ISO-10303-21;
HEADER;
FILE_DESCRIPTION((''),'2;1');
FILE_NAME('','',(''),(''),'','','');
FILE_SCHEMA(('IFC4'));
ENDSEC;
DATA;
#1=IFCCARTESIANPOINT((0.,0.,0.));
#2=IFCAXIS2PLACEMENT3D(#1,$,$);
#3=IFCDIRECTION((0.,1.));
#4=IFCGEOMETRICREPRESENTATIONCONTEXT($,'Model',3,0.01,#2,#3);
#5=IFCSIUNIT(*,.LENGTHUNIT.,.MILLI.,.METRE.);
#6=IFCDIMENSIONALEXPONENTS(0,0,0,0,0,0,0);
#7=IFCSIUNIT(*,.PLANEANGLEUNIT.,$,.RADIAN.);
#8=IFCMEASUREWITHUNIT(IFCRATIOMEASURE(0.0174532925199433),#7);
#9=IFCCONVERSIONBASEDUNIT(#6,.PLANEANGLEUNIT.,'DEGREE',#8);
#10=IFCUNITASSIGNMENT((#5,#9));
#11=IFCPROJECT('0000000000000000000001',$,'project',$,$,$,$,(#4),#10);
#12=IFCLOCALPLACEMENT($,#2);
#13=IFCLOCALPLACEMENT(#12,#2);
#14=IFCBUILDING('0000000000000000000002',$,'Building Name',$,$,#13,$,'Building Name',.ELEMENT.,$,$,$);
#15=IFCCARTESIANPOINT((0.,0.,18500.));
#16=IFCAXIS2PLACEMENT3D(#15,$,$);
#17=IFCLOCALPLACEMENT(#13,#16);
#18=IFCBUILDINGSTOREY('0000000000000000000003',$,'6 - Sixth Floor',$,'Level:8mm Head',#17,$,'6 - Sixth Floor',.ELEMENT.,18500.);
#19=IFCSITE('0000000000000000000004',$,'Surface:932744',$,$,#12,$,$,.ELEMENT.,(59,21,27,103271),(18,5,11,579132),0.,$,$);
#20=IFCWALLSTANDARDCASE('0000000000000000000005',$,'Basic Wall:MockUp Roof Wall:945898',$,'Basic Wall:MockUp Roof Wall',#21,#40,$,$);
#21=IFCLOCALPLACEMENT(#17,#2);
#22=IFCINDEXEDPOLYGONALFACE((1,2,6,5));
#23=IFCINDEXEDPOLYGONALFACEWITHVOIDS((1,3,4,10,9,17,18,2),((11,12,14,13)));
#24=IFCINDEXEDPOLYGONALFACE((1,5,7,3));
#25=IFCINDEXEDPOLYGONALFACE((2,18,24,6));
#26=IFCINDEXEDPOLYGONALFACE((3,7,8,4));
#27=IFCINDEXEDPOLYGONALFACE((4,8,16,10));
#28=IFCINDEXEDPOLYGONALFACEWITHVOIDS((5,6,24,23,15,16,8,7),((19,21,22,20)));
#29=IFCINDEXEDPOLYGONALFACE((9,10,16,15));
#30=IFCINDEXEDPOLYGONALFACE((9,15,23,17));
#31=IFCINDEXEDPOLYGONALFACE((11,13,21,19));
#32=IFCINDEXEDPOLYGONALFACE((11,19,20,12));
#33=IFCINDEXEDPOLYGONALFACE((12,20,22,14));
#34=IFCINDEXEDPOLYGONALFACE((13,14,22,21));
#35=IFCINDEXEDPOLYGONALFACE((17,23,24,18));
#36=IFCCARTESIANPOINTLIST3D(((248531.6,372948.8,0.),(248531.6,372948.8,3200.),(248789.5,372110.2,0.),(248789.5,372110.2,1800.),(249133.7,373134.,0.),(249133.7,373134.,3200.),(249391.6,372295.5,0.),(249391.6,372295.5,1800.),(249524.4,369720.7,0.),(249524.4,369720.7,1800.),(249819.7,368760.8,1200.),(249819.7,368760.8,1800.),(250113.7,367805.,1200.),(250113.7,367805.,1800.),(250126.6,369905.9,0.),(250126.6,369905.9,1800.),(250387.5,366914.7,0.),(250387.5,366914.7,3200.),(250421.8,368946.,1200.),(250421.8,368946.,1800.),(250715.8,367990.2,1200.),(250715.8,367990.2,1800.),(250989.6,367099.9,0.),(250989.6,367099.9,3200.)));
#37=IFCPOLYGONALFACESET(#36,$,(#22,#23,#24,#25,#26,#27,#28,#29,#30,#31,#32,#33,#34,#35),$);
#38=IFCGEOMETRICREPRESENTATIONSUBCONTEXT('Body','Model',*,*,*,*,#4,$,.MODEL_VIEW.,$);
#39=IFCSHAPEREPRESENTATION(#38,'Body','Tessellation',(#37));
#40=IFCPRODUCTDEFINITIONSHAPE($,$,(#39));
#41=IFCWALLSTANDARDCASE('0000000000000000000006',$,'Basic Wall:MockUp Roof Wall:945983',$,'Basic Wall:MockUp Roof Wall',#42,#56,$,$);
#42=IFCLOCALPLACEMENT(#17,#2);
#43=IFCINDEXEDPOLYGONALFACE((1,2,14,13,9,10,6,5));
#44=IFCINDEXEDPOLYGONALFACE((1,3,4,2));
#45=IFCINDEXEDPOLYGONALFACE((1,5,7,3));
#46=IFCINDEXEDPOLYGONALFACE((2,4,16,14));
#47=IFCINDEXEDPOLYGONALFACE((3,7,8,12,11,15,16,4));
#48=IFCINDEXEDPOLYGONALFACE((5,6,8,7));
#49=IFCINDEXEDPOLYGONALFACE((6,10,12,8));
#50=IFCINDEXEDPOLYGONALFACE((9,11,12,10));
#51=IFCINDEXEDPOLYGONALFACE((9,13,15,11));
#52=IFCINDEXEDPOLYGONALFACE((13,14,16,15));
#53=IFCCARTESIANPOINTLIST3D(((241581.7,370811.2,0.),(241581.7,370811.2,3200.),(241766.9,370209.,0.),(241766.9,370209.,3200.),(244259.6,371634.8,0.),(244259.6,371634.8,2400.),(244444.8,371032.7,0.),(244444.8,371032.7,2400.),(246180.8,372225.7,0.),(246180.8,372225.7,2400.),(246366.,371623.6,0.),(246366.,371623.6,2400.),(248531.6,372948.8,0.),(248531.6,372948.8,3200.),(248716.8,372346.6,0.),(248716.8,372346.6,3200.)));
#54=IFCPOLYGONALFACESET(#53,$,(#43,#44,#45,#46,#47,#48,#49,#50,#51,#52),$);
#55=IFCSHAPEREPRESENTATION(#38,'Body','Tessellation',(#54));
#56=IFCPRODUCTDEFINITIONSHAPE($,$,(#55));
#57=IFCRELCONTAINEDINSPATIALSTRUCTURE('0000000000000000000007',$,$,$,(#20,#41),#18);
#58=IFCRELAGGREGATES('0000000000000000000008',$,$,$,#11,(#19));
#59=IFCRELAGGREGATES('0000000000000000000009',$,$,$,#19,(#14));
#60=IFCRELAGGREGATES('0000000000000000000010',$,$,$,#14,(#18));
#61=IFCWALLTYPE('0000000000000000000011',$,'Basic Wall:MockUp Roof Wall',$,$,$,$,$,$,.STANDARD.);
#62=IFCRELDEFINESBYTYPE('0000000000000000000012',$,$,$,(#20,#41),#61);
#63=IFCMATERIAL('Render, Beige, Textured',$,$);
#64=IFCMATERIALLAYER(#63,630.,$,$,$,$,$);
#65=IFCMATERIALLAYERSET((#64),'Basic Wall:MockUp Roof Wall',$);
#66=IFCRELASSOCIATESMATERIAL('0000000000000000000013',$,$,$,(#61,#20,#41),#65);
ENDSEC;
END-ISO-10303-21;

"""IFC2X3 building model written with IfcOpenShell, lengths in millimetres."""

from ifc_helpers import new_model, entity, si_unit, converted_unit, direction, frame, frame_2d, origin, place, context, subcontext, project, spatial, rectangle, extrude, material, layer, layer_set, layer_usage, type_object, element, save


model = new_model("IFC2X3")

# Units and contexts
model_context = context("Model", 3, precision=0.01, world=origin(), true_north=direction((0.0, 1.0)))
body_context = subcontext(model_context, "Body", "Model", "MODEL_VIEW")
ifc_project = project(units=[si_unit("LENGTHUNIT", "METRE", prefix="MILLI"), converted_unit("PLANEANGLEUNIT", "DEGREE", entity("IfcRatioMeasure", 0.0174532925199433), si_unit("PLANEANGLEUNIT", "RADIAN"), dimensions=[0, 0, 0, 0, 0, 0, 0])], contexts=[model_context])

# Site, building, storey
site_placement = place(None, origin())
site = spatial("IfcSite", under=ifc_project, at=site_placement, Name="Surface:932744", CompositionType="ELEMENT", RefLatitude=(59, 21, 27, 103271), RefLongitude=(18, 5, 11, 579132), RefElevation=0.0)
building_placement = place(site_placement, origin())
building = spatial("IfcBuilding", under=site, at=building_placement, Name="Building Name", LongName="Building Name", CompositionType="ELEMENT")
storey_placement = place(building_placement, frame((0.0, 0.0, 18500.0)))
storey = spatial("IfcBuildingStorey", under=building, at=storey_placement, Name="6 - Sixth Floor", ObjectType="Level:8mm Head", LongName="6 - Sixth Floor", CompositionType="ELEMENT", Elevation=18500.0)

# Shared definitions
ifc_material_1 = material(Name="Render, Beige, Textured")
ifc_layer_1 = layer(ifc_material_1, 630.0)
ifc_layer_set_1 = layer_set([ifc_layer_1], Name="Basic Wall:MockUp Roof Wall")
wall_type_1 = type_object("IfcWallType", Name="Basic Wall:MockUp Roof Wall", PredefinedType="STANDARD", material=ifc_layer_set_1)

# Wall, openings
ifc_layer_usage_1 = layer_usage(ifc_layer_set_1, "AXIS2", "NEGATIVE", 315.0)
wall_1_placement = place(storey_placement, frame((250688.5, 367007.3, 0.0), z_axis=(0.0, 0.0, 1.0), x_axis=(-0.29398, 0.955811, 0.0)))
wall_1 = element("IfcWallStandardCase", 1, at=wall_1_placement, inside=storey, type_object=wall_type_1, material=ifc_layer_usage_1, Name="Basic Wall:MockUp Roof Wall:945898", ObjectType="Basic Wall:MockUp Roof Wall", context=body_context, shape_type="SweptSolid", body=[
    extrude(rectangle(XDim=6313.0, YDim=630.0, at=frame_2d((3156.5, 0.0), x_axis=(-1.0, 0.0))), origin(), (0.0, 0.0, 1.0), 3200.0),
])
opening_1_placement = place(wall_1_placement, frame((5435.7, 315.0, 0.0)))
element("IfcOpeningElement", 2, at=opening_1_placement, cuts=wall_1, ObjectType="Opening", context=body_context, shape_type="SweptSolid", body=[
    extrude(rectangle(XDim=1800.0, YDim=2500.0, at=frame_2d((900.0, 1250.0), x_axis=(1.0, 0.0))), frame((0.0, 0.0, 0.0), z_axis=(0.0, -1.0, 0.0), x_axis=(0.0, 0.0, 1.0)), (0.0, 0.0, 1.0), 630.0),
])
opening_2_placement = place(wall_1_placement, frame((1931.4, 315.0, 1200.0)))
element("IfcOpeningElement", 3, at=opening_2_placement, cuts=wall_1, ObjectType="Opening", context=body_context, shape_type="SweptSolid", body=[
    extrude(rectangle(XDim=600.0, YDim=1000.0, at=frame_2d((300.0, 500.0), x_axis=(1.0, 0.0))), frame((0.0, 0.0, 0.0), z_axis=(0.0, -1.0, 0.0), x_axis=(0.0, 0.0, 1.0)), (0.0, 0.0, 1.0), 630.0),
])

# Wall, opening
ifc_layer_usage_2 = layer_usage(ifc_layer_set_1, "AXIS2", "NEGATIVE", 315.0)
wall_2_placement = place(storey_placement, frame((248624.2, 372647.7, 0.0), z_axis=(0.0, 0.0, 1.0), x_axis=(-0.955811, -0.29398, 0.0)))
wall_2 = element("IfcWallStandardCase", 4, at=wall_2_placement, inside=storey, type_object=wall_type_1, material=ifc_layer_usage_2, Name="Basic Wall:MockUp Roof Wall:945983", ObjectType="Basic Wall:MockUp Roof Wall", context=body_context, shape_type="SweptSolid", body=[
    extrude(rectangle(XDim=7271.1, YDim=630.0, at=frame_2d((3635.6, 0.0), x_axis=(-1.0, 0.0))), origin(), (0.0, 0.0, 1.0), 3200.0),
])
opening_3_placement = place(wall_2_placement, frame((4469.5, 315.0, 0.0)))
element("IfcOpeningElement", 5, at=opening_3_placement, cuts=wall_2, ObjectType="Opening", context=body_context, shape_type="SweptSolid", body=[
    extrude(rectangle(XDim=2400.0, YDim=2010.0, at=frame_2d((1200.0, 1005.0), x_axis=(1.0, 0.0))), frame((0.0, 0.0, 0.0), z_axis=(0.0, -1.0, 0.0), x_axis=(0.0, 0.0, 1.0)), (0.0, 0.0, 1.0), 630.0),
])

save(model, "model.ifc")
